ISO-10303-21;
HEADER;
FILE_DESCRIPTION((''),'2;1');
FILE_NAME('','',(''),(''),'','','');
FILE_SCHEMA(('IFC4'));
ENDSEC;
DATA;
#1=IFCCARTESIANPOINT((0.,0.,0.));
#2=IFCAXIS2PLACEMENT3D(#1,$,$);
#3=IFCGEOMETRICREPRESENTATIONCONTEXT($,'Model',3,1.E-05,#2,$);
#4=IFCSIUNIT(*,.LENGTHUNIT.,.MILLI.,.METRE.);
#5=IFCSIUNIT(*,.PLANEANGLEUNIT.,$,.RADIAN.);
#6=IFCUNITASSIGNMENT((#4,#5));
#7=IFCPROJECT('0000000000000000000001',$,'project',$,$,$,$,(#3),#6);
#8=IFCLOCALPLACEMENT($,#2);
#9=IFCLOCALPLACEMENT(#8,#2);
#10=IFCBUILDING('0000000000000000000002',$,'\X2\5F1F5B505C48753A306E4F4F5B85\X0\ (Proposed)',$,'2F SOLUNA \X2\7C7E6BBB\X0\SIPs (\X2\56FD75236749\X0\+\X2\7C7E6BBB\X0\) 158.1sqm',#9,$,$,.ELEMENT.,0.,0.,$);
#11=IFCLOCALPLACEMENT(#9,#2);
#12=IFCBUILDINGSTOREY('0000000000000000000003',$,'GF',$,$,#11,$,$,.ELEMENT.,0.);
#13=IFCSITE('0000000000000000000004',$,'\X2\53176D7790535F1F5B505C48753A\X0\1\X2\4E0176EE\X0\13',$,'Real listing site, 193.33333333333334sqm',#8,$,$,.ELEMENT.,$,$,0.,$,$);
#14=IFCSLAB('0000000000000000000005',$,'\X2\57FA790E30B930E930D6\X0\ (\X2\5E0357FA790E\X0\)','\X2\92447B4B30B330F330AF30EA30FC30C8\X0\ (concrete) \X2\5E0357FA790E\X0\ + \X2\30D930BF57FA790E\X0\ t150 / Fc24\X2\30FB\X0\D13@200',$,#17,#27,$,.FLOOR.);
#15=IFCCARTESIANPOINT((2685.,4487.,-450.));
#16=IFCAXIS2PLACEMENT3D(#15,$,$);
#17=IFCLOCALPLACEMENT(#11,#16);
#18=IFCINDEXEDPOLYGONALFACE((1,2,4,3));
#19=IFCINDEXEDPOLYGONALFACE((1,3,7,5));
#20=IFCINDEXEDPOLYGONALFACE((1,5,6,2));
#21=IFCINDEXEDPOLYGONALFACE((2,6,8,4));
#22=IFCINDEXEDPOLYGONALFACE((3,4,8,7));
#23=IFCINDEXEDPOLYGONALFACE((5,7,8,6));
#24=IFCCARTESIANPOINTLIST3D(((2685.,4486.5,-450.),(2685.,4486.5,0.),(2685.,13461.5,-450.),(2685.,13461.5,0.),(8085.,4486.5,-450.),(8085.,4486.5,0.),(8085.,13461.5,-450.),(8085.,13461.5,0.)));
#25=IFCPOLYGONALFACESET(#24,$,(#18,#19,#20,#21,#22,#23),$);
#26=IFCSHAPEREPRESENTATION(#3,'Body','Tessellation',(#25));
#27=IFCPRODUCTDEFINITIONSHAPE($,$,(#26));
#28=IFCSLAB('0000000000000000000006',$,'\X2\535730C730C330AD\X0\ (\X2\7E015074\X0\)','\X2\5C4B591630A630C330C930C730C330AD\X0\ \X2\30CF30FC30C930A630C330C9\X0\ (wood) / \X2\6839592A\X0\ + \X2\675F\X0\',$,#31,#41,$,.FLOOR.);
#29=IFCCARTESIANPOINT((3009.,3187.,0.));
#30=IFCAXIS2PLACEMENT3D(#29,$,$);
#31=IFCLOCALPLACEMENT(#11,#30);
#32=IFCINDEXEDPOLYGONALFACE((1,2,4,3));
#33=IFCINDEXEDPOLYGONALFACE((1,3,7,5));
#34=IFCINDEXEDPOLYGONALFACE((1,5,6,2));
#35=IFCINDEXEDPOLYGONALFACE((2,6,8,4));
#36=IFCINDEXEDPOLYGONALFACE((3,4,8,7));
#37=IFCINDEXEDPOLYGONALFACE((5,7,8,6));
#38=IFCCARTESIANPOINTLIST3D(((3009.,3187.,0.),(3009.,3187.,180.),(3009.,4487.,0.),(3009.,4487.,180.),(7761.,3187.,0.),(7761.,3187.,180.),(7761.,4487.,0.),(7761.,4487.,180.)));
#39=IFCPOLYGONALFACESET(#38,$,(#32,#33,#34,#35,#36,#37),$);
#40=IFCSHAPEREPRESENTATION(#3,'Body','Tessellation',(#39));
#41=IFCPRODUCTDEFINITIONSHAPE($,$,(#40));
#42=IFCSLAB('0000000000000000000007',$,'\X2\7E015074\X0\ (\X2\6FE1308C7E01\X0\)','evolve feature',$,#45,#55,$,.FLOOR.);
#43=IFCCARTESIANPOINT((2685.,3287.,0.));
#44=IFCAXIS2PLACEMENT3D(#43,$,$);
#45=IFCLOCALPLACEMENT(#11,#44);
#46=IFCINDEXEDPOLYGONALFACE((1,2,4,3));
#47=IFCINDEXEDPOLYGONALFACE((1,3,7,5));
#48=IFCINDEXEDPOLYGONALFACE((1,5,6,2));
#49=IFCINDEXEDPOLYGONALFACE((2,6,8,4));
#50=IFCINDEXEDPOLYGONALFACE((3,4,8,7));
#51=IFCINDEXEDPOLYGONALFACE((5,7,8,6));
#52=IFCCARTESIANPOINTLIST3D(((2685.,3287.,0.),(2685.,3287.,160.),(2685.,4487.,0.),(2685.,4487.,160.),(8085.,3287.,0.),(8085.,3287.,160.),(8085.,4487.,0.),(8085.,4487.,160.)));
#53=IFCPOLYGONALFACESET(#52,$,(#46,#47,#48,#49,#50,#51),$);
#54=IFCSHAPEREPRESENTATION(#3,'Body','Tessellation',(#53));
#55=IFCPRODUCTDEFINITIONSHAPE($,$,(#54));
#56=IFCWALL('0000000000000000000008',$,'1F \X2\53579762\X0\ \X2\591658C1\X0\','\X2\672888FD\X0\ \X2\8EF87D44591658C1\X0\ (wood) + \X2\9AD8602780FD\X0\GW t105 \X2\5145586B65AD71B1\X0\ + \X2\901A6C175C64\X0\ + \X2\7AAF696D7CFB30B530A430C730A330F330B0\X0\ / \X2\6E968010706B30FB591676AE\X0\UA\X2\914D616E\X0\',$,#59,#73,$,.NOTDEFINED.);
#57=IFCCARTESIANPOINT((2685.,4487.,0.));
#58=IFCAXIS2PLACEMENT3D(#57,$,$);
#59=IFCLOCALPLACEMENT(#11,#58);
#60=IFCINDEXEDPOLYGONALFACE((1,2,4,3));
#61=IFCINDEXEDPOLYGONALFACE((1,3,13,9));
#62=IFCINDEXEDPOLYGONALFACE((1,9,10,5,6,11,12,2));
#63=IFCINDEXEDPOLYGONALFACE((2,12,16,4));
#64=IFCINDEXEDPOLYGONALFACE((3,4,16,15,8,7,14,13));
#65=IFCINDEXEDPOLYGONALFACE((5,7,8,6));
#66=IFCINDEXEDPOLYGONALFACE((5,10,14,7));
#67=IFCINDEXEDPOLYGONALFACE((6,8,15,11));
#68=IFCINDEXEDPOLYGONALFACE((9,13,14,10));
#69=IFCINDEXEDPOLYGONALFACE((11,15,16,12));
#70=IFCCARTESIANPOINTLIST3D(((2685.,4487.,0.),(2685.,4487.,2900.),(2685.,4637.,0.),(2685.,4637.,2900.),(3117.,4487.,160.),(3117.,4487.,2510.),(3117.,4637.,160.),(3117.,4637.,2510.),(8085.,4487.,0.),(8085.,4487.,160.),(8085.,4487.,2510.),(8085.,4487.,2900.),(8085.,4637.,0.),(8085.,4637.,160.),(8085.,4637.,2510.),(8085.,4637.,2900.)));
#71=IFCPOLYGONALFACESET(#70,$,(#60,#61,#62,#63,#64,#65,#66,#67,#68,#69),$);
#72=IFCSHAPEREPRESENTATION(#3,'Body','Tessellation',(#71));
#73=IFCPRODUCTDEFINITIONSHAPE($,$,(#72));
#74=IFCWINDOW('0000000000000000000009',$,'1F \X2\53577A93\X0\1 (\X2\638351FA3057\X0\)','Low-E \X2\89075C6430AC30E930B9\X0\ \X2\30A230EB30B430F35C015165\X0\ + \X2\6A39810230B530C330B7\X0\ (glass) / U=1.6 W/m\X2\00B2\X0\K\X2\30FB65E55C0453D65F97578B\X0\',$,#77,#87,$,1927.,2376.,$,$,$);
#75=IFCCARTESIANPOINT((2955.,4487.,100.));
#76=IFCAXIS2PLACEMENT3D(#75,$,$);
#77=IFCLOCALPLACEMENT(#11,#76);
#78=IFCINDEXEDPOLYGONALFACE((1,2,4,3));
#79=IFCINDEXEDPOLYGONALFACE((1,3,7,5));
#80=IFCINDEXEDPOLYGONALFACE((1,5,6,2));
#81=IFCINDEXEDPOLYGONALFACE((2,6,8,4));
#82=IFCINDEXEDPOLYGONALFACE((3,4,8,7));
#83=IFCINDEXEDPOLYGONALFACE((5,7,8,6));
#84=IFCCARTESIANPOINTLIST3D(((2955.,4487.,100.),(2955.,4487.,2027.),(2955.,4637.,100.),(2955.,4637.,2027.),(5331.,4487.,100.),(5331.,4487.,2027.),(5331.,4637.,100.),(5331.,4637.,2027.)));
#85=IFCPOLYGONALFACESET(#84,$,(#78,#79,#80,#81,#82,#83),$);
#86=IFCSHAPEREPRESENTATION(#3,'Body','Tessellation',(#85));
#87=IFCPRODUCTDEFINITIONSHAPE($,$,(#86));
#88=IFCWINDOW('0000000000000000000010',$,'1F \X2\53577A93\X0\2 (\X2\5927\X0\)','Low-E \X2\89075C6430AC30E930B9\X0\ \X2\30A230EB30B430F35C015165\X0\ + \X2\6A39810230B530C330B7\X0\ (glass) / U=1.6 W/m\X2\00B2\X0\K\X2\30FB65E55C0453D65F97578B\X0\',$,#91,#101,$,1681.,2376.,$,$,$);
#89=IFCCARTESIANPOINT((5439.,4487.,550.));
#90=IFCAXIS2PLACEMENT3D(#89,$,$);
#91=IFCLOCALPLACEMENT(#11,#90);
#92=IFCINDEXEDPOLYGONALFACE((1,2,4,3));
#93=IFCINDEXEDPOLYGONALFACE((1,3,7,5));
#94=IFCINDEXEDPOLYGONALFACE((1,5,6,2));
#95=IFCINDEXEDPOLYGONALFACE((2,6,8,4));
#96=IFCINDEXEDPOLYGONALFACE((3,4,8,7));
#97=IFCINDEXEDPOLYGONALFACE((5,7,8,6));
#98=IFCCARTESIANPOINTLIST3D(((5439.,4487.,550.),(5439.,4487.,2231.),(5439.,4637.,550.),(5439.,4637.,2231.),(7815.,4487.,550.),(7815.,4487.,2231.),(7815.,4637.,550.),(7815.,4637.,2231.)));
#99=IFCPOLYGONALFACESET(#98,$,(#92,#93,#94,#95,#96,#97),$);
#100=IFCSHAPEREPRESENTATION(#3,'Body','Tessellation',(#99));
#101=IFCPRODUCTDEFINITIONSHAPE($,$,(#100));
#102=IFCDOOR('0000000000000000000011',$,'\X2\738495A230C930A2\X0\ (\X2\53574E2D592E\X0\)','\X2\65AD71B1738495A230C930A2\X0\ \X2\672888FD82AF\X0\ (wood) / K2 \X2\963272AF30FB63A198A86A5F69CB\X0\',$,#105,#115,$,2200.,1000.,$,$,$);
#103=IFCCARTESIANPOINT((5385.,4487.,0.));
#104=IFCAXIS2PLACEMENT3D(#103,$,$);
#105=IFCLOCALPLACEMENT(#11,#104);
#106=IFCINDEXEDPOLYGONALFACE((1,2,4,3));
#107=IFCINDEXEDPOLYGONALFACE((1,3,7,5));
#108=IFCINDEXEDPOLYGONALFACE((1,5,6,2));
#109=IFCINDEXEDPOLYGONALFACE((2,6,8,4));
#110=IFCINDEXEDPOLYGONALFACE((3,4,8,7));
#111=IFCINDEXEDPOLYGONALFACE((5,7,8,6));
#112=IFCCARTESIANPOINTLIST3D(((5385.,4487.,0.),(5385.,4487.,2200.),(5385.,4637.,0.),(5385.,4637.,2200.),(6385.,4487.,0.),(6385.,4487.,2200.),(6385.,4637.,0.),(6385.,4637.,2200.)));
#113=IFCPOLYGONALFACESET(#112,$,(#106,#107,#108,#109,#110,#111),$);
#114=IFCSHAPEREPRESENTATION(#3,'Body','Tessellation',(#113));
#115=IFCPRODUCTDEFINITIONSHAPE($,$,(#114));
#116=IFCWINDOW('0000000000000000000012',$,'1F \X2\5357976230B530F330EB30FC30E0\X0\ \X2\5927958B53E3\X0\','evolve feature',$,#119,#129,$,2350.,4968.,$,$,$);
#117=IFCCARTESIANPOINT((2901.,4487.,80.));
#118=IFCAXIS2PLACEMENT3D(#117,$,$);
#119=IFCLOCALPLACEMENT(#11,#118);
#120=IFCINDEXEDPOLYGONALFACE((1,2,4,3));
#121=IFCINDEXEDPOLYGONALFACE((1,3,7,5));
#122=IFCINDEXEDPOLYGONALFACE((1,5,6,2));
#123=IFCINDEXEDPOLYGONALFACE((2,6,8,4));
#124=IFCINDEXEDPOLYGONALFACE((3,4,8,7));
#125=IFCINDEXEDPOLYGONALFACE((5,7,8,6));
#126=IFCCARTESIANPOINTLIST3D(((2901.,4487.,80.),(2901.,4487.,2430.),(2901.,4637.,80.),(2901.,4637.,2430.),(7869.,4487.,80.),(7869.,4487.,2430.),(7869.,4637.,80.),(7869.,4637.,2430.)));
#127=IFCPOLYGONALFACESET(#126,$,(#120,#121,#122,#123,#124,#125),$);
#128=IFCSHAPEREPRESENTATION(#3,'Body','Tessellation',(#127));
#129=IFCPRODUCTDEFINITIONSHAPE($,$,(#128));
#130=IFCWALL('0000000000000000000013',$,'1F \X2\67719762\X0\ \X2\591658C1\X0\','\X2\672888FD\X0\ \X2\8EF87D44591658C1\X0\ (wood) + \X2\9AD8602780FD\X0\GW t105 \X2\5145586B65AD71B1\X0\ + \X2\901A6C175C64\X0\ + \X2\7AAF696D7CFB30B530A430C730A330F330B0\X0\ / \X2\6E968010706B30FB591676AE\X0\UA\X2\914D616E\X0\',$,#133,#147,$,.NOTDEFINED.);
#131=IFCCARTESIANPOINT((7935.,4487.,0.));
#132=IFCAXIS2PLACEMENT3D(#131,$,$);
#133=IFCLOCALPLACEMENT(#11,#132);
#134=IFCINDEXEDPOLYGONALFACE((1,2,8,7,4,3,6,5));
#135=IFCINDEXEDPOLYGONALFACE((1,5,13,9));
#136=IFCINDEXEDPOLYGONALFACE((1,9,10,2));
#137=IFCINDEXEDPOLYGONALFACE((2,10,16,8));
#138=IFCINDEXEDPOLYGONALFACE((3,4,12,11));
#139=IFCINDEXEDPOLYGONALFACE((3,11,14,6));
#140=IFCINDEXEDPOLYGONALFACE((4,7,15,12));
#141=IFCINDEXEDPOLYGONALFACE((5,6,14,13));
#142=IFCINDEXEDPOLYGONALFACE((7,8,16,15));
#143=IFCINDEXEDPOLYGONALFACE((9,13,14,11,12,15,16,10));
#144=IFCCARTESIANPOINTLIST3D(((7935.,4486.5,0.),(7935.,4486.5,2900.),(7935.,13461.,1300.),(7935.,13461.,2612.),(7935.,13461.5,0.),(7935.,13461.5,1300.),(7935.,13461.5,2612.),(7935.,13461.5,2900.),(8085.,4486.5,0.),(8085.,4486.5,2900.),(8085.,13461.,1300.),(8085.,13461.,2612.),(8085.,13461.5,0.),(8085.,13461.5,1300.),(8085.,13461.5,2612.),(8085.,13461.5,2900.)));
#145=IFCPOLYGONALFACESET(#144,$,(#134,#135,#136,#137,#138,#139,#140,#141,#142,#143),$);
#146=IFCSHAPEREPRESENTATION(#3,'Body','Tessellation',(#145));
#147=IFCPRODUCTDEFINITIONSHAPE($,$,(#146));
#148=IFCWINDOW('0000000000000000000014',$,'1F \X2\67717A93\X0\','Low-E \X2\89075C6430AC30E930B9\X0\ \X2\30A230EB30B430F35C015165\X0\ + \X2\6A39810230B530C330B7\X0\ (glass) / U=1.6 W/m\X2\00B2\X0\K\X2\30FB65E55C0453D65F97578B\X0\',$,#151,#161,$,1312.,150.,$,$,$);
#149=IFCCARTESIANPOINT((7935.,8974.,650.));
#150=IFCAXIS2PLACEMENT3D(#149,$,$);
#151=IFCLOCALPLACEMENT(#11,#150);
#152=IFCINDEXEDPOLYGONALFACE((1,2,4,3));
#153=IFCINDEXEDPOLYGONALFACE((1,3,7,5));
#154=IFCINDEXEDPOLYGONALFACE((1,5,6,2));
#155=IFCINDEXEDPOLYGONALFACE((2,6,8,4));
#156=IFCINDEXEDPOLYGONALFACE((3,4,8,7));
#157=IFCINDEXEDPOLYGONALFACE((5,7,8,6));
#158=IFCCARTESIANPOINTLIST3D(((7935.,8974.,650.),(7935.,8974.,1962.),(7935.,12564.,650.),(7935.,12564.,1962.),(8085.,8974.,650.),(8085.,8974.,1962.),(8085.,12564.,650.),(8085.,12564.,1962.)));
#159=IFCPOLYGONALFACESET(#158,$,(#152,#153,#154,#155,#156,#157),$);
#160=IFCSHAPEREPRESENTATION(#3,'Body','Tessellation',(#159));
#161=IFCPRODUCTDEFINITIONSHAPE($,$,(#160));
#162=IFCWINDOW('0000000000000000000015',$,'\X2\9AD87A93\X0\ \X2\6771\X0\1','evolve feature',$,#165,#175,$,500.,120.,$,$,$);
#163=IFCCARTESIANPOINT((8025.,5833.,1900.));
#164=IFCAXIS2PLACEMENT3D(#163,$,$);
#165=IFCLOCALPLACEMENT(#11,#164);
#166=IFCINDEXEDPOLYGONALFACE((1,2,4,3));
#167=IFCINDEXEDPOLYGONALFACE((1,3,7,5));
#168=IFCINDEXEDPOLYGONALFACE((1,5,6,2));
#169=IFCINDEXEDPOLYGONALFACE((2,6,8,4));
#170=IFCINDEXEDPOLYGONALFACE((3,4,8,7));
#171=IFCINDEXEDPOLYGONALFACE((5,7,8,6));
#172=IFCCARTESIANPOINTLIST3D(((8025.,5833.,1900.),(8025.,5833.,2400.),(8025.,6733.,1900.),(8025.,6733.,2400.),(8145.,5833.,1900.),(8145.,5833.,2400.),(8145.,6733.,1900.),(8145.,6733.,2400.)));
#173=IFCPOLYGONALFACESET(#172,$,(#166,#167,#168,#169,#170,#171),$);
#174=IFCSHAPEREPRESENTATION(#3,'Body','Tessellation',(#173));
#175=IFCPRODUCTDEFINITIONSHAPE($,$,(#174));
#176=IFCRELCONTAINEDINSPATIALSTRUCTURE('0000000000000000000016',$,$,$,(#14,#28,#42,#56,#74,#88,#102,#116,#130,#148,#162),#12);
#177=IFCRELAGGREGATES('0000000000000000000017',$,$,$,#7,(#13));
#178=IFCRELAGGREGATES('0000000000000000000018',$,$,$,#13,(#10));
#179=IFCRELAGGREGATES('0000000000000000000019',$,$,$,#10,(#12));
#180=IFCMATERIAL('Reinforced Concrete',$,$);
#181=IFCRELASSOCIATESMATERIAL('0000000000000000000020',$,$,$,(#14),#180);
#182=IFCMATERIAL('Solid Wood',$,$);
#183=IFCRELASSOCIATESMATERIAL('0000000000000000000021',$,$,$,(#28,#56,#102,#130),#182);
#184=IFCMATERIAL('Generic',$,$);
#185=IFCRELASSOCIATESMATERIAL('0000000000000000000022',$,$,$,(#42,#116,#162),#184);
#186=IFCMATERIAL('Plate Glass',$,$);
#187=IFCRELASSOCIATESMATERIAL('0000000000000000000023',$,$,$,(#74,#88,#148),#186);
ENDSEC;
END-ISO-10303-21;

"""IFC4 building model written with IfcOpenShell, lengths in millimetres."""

from ifc_helpers import new_model, si_unit, frame, frame_2d, origin, place, context, project, spatial, rectangle, extrude, material, element, fill, save


model = new_model("IFC4")

# Units and contexts
model_context = context("Model", 3, precision=1e-05, world=origin())
ifc_project = project(units=[si_unit("LENGTHUNIT", "METRE", prefix="MILLI"), si_unit("PLANEANGLEUNIT", "RADIAN")], contexts=[model_context])

# Site, building, storey
site_placement = place(None, origin())
site = spatial("IfcSite", under=ifc_project, at=site_placement, Name="北海道弟子屈町1丁目13", ObjectType="Real listing site, 193.33333333333334sqm", CompositionType="ELEMENT", RefElevation=0.0)
building_placement = place(site_placement, origin())
building = spatial("IfcBuilding", under=site, at=building_placement, Name="弟子屈町の住宅 (Proposed)", ObjectType="2F SOLUNA 籾殻SIPs (国産杉+籾殻) 158.1sqm", CompositionType="ELEMENT", ElevationOfRefHeight=0.0, ElevationOfTerrain=0.0)
storey_placement = place(building_placement, origin())
storey = spatial("IfcBuildingStorey", under=building, at=storey_placement, Name="GF", CompositionType="ELEMENT", Elevation=0.0)

# Slabs
ifc_material_1 = material(Name="Reinforced Concrete")
slab_1_placement = place(storey_placement, frame((2685.0, 4487.0, -450.0)))
element("IfcSlab", 1, at=slab_1_placement, inside=storey, material=ifc_material_1, Name="基礎スラブ (布基礎)", Description="鉄筋コンクリート (concrete) 布基礎 + ベタ基礎 t150 / Fc24・D13@200", PredefinedType="FLOOR", context=model_context, shape_type="SweptSolid", body=[
    extrude(rectangle(XDim=5400.0, YDim=8975.0, at=frame_2d((2700.0, 4487.0))), frame((2685.0, 4487.0, -450.0)), (0.0, 0.0, 1.0), 450.0),
])
ifc_material_2 = material(Name="Solid Wood")
slab_2_placement = place(storey_placement, frame((3009.0, 3187.0, 0.0)))
element("IfcSlab", 2, at=slab_2_placement, inside=storey, material=ifc_material_2, Name="南デッキ (縁側)", Description="屋外ウッドデッキ ハードウッド (wood) / 根太 + 束", PredefinedType="FLOOR", context=model_context, shape_type="SweptSolid", body=[
    extrude(rectangle(XDim=4752.0, YDim=1300.0, at=frame_2d((2376.0, 650.0))), frame((3009.0, 3187.0, 0.0)), (0.0, 0.0, 1.0), 180.0),
])
ifc_material_3 = material(Name="Generic")
slab_3_placement = place(storey_placement, frame((2685.0, 3287.0, 0.0)))
element("IfcSlab", 3, at=slab_3_placement, inside=storey, material=ifc_material_3, Name="縁側 (濡れ縁)", Description="evolve feature", PredefinedType="FLOOR", context=model_context, shape_type="SweptSolid", body=[
    extrude(rectangle(XDim=5400.0, YDim=1200.0, at=frame_2d((2700.0, 600.0))), frame((2685.0, 3287.0, 0.0)), (0.0, 0.0, 1.0), 160.0),
])

# Wall, openings, windows, door
wall_1_placement = place(storey_placement, frame((2685.0, 4487.0, 0.0)))
wall_1 = element("IfcWall", 4, at=wall_1_placement, inside=storey, material=ifc_material_2, Name="1F 南面 外壁", Description="木製 軸組外壁 (wood) + 高性能GW t105 充填断熱 + 通気層 + 窯業系サイディング / 準耐火・外皮UA配慮", PredefinedType="NOTDEFINED", context=model_context, shape_type="SweptSolid", body=[
    extrude(rectangle(XDim=5400.0, YDim=150.0, at=frame_2d((2700.0, 75.0))), frame((2685.0, 4487.0, 0.0)), (0.0, 0.0, 1.0), 2900.0),
])
opening_1_placement = place(storey_placement, frame((2955.0, 4487.0, 100.0)))
opening_1 = element("IfcOpeningElement", 5, at=opening_1_placement, cuts=wall_1, PredefinedType="NOTDEFINED", context=model_context, shape_type="SweptSolid", body=[
    extrude(rectangle(XDim=2376.0, YDim=150.0, at=frame_2d((1188.0, 75.0))), frame((2955.0, 4487.0, 100.0)), (0.0, 0.0, 1.0), 1927.0),
])
opening_2_placement = place(storey_placement, frame((5439.0, 4487.0, 550.0)))
opening_2 = element("IfcOpeningElement", 6, at=opening_2_placement, cuts=wall_1, PredefinedType="NOTDEFINED", context=model_context, shape_type="SweptSolid", body=[
    extrude(rectangle(XDim=2376.0, YDim=150.0, at=frame_2d((1188.0, 75.0))), frame((5439.0, 4487.0, 550.0)), (0.0, 0.0, 1.0), 1681.0),
])
opening_3_placement = place(storey_placement, frame((5385.0, 4487.0, 0.0)))
opening_3 = element("IfcOpeningElement", 7, at=opening_3_placement, cuts=wall_1, PredefinedType="NOTDEFINED", context=model_context, shape_type="SweptSolid", body=[
    extrude(rectangle(XDim=1000.0, YDim=150.0, at=frame_2d((500.0, 75.0))), frame((5385.0, 4487.0, 0.0)), (0.0, 0.0, 1.0), 2200.0),
])
opening_4_placement = place(storey_placement, frame((2901.0, 4487.0, 80.0)))
opening_4 = element("IfcOpeningElement", 8, at=opening_4_placement, cuts=wall_1, PredefinedType="NOTDEFINED", context=model_context, shape_type="SweptSolid", body=[
    extrude(rectangle(XDim=4968.0, YDim=150.0, at=frame_2d((2484.0, 75.0))), frame((2901.0, 4487.0, 80.0)), (0.0, 0.0, 1.0), 2350.0),
])
ifc_material_4 = material(Name="Plate Glass")
window_1_placement = place(storey_placement, frame((2955.0, 4487.0, 100.0)))
window_1 = element("IfcWindow", 9, at=window_1_placement, inside=storey, material=ifc_material_4, Name="1F 南窓1 (掃出し)", Description="Low-E 複層ガラス アルゴン封入 + 樹脂サッシ (glass) / U=1.6 W/m²K・日射取得型", OverallHeight=1927.0, OverallWidth=2376.0, context=model_context, shape_type="SweptSolid", body=[
    extrude(rectangle(XDim=2376.0, YDim=150.0, at=frame_2d((1188.0, 75.0))), frame((2955.0, 4487.0, 100.0)), (0.0, 0.0, 1.0), 1927.0),
])
fill(opening_1, window_1)
window_2_placement = place(storey_placement, frame((5439.0, 4487.0, 550.0)))
window_2 = element("IfcWindow", 10, at=window_2_placement, inside=storey, material=ifc_material_4, Name="1F 南窓2 (大)", Description="Low-E 複層ガラス アルゴン封入 + 樹脂サッシ (glass) / U=1.6 W/m²K・日射取得型", OverallHeight=1681.0, OverallWidth=2376.0, context=model_context, shape_type="SweptSolid", body=[
    extrude(rectangle(XDim=2376.0, YDim=150.0, at=frame_2d((1188.0, 75.0))), frame((5439.0, 4487.0, 550.0)), (0.0, 0.0, 1.0), 1681.0),
])
fill(opening_2, window_2)
door_placement = place(storey_placement, frame((5385.0, 4487.0, 0.0)))
door = element("IfcDoor", 11, at=door_placement, inside=storey, material=ifc_material_2, Name="玄関ドア (南中央)", Description="断熱玄関ドア 木製芯 (wood) / K2 防犯・採風機構", OverallHeight=2200.0, OverallWidth=1000.0, context=model_context, shape_type="SweptSolid", body=[
    extrude(rectangle(XDim=1000.0, YDim=150.0, at=frame_2d((500.0, 75.0))), frame((5385.0, 4487.0, 0.0)), (0.0, 0.0, 1.0), 2200.0),
])
fill(opening_3, door)
window_3_placement = place(storey_placement, frame((2901.0, 4487.0, 80.0)))
window_3 = element("IfcWindow", 12, at=window_3_placement, inside=storey, material=ifc_material_3, Name="1F 南面サンルーム 大開口", Description="evolve feature", OverallHeight=2350.0, OverallWidth=4968.0, context=model_context, shape_type="SweptSolid", body=[
    extrude(rectangle(XDim=4968.0, YDim=150.0, at=frame_2d((2484.0, 75.0))), frame((2901.0, 4487.0, 80.0)), (0.0, 0.0, 1.0), 2350.0),
])
fill(opening_4, window_3)

# Wall, openings, windows
wall_2_placement = place(storey_placement, frame((7935.0, 4487.0, 0.0)))
wall_2 = element("IfcWall", 13, at=wall_2_placement, inside=storey, material=ifc_material_2, Name="1F 東面 外壁", Description="木製 軸組外壁 (wood) + 高性能GW t105 充填断熱 + 通気層 + 窯業系サイディング / 準耐火・外皮UA配慮", PredefinedType="NOTDEFINED", context=model_context, shape_type="SweptSolid", body=[
    extrude(rectangle(XDim=150.0, YDim=8975.0, at=frame_2d((75.0, 4487.0))), frame((7935.0, 4487.0, 0.0)), (0.0, 0.0, 1.0), 2900.0),
])
opening_5_placement = place(storey_placement, frame((7935.0, 8974.0, 650.0)))
opening_5 = element("IfcOpeningElement", 14, at=opening_5_placement, cuts=wall_2, PredefinedType="NOTDEFINED", context=model_context, shape_type="SweptSolid", body=[
    extrude(rectangle(XDim=150.0, YDim=3590.0, at=frame_2d((75.0, 1795.0))), frame((7935.0, 8974.0, 650.0)), (0.0, 0.0, 1.0), 1312.0),
])
opening_6_placement = place(storey_placement, frame((8025.0, 5833.0, 1900.0)))
opening_6 = element("IfcOpeningElement", 15, at=opening_6_placement, cuts=wall_2, PredefinedType="NOTDEFINED", context=model_context, shape_type="SweptSolid", body=[
    extrude(rectangle(XDim=120.0, YDim=900.0, at=frame_2d((60.0, 450.0))), frame((8025.0, 5833.0, 1900.0)), (0.0, 0.0, 1.0), 500.0),
])
window_4_placement = place(storey_placement, frame((7935.0, 8974.0, 650.0)))
window_4 = element("IfcWindow", 16, at=window_4_placement, inside=storey, material=ifc_material_4, Name="1F 東窓", Description="Low-E 複層ガラス アルゴン封入 + 樹脂サッシ (glass) / U=1.6 W/m²K・日射取得型", OverallHeight=1312.0, OverallWidth=150.0, context=model_context, shape_type="SweptSolid", body=[
    extrude(rectangle(XDim=150.0, YDim=3590.0, at=frame_2d((75.0, 1795.0))), frame((7935.0, 8974.0, 650.0)), (0.0, 0.0, 1.0), 1312.0),
])
fill(opening_5, window_4)
window_5_placement = place(storey_placement, frame((8025.0, 5833.0, 1900.0)))
window_5 = element("IfcWindow", 17, at=window_5_placement, inside=storey, material=ifc_material_3, Name="高窓 東1", Description="evolve feature", OverallHeight=500.0, OverallWidth=120.0, context=model_context, shape_type="SweptSolid", body=[
    extrude(rectangle(XDim=120.0, YDim=900.0, at=frame_2d((60.0, 450.0))), frame((8025.0, 5833.0, 1900.0)), (0.0, 0.0, 1.0), 500.0),
])
fill(opening_6, window_5)

save(model, "model.ifc")
